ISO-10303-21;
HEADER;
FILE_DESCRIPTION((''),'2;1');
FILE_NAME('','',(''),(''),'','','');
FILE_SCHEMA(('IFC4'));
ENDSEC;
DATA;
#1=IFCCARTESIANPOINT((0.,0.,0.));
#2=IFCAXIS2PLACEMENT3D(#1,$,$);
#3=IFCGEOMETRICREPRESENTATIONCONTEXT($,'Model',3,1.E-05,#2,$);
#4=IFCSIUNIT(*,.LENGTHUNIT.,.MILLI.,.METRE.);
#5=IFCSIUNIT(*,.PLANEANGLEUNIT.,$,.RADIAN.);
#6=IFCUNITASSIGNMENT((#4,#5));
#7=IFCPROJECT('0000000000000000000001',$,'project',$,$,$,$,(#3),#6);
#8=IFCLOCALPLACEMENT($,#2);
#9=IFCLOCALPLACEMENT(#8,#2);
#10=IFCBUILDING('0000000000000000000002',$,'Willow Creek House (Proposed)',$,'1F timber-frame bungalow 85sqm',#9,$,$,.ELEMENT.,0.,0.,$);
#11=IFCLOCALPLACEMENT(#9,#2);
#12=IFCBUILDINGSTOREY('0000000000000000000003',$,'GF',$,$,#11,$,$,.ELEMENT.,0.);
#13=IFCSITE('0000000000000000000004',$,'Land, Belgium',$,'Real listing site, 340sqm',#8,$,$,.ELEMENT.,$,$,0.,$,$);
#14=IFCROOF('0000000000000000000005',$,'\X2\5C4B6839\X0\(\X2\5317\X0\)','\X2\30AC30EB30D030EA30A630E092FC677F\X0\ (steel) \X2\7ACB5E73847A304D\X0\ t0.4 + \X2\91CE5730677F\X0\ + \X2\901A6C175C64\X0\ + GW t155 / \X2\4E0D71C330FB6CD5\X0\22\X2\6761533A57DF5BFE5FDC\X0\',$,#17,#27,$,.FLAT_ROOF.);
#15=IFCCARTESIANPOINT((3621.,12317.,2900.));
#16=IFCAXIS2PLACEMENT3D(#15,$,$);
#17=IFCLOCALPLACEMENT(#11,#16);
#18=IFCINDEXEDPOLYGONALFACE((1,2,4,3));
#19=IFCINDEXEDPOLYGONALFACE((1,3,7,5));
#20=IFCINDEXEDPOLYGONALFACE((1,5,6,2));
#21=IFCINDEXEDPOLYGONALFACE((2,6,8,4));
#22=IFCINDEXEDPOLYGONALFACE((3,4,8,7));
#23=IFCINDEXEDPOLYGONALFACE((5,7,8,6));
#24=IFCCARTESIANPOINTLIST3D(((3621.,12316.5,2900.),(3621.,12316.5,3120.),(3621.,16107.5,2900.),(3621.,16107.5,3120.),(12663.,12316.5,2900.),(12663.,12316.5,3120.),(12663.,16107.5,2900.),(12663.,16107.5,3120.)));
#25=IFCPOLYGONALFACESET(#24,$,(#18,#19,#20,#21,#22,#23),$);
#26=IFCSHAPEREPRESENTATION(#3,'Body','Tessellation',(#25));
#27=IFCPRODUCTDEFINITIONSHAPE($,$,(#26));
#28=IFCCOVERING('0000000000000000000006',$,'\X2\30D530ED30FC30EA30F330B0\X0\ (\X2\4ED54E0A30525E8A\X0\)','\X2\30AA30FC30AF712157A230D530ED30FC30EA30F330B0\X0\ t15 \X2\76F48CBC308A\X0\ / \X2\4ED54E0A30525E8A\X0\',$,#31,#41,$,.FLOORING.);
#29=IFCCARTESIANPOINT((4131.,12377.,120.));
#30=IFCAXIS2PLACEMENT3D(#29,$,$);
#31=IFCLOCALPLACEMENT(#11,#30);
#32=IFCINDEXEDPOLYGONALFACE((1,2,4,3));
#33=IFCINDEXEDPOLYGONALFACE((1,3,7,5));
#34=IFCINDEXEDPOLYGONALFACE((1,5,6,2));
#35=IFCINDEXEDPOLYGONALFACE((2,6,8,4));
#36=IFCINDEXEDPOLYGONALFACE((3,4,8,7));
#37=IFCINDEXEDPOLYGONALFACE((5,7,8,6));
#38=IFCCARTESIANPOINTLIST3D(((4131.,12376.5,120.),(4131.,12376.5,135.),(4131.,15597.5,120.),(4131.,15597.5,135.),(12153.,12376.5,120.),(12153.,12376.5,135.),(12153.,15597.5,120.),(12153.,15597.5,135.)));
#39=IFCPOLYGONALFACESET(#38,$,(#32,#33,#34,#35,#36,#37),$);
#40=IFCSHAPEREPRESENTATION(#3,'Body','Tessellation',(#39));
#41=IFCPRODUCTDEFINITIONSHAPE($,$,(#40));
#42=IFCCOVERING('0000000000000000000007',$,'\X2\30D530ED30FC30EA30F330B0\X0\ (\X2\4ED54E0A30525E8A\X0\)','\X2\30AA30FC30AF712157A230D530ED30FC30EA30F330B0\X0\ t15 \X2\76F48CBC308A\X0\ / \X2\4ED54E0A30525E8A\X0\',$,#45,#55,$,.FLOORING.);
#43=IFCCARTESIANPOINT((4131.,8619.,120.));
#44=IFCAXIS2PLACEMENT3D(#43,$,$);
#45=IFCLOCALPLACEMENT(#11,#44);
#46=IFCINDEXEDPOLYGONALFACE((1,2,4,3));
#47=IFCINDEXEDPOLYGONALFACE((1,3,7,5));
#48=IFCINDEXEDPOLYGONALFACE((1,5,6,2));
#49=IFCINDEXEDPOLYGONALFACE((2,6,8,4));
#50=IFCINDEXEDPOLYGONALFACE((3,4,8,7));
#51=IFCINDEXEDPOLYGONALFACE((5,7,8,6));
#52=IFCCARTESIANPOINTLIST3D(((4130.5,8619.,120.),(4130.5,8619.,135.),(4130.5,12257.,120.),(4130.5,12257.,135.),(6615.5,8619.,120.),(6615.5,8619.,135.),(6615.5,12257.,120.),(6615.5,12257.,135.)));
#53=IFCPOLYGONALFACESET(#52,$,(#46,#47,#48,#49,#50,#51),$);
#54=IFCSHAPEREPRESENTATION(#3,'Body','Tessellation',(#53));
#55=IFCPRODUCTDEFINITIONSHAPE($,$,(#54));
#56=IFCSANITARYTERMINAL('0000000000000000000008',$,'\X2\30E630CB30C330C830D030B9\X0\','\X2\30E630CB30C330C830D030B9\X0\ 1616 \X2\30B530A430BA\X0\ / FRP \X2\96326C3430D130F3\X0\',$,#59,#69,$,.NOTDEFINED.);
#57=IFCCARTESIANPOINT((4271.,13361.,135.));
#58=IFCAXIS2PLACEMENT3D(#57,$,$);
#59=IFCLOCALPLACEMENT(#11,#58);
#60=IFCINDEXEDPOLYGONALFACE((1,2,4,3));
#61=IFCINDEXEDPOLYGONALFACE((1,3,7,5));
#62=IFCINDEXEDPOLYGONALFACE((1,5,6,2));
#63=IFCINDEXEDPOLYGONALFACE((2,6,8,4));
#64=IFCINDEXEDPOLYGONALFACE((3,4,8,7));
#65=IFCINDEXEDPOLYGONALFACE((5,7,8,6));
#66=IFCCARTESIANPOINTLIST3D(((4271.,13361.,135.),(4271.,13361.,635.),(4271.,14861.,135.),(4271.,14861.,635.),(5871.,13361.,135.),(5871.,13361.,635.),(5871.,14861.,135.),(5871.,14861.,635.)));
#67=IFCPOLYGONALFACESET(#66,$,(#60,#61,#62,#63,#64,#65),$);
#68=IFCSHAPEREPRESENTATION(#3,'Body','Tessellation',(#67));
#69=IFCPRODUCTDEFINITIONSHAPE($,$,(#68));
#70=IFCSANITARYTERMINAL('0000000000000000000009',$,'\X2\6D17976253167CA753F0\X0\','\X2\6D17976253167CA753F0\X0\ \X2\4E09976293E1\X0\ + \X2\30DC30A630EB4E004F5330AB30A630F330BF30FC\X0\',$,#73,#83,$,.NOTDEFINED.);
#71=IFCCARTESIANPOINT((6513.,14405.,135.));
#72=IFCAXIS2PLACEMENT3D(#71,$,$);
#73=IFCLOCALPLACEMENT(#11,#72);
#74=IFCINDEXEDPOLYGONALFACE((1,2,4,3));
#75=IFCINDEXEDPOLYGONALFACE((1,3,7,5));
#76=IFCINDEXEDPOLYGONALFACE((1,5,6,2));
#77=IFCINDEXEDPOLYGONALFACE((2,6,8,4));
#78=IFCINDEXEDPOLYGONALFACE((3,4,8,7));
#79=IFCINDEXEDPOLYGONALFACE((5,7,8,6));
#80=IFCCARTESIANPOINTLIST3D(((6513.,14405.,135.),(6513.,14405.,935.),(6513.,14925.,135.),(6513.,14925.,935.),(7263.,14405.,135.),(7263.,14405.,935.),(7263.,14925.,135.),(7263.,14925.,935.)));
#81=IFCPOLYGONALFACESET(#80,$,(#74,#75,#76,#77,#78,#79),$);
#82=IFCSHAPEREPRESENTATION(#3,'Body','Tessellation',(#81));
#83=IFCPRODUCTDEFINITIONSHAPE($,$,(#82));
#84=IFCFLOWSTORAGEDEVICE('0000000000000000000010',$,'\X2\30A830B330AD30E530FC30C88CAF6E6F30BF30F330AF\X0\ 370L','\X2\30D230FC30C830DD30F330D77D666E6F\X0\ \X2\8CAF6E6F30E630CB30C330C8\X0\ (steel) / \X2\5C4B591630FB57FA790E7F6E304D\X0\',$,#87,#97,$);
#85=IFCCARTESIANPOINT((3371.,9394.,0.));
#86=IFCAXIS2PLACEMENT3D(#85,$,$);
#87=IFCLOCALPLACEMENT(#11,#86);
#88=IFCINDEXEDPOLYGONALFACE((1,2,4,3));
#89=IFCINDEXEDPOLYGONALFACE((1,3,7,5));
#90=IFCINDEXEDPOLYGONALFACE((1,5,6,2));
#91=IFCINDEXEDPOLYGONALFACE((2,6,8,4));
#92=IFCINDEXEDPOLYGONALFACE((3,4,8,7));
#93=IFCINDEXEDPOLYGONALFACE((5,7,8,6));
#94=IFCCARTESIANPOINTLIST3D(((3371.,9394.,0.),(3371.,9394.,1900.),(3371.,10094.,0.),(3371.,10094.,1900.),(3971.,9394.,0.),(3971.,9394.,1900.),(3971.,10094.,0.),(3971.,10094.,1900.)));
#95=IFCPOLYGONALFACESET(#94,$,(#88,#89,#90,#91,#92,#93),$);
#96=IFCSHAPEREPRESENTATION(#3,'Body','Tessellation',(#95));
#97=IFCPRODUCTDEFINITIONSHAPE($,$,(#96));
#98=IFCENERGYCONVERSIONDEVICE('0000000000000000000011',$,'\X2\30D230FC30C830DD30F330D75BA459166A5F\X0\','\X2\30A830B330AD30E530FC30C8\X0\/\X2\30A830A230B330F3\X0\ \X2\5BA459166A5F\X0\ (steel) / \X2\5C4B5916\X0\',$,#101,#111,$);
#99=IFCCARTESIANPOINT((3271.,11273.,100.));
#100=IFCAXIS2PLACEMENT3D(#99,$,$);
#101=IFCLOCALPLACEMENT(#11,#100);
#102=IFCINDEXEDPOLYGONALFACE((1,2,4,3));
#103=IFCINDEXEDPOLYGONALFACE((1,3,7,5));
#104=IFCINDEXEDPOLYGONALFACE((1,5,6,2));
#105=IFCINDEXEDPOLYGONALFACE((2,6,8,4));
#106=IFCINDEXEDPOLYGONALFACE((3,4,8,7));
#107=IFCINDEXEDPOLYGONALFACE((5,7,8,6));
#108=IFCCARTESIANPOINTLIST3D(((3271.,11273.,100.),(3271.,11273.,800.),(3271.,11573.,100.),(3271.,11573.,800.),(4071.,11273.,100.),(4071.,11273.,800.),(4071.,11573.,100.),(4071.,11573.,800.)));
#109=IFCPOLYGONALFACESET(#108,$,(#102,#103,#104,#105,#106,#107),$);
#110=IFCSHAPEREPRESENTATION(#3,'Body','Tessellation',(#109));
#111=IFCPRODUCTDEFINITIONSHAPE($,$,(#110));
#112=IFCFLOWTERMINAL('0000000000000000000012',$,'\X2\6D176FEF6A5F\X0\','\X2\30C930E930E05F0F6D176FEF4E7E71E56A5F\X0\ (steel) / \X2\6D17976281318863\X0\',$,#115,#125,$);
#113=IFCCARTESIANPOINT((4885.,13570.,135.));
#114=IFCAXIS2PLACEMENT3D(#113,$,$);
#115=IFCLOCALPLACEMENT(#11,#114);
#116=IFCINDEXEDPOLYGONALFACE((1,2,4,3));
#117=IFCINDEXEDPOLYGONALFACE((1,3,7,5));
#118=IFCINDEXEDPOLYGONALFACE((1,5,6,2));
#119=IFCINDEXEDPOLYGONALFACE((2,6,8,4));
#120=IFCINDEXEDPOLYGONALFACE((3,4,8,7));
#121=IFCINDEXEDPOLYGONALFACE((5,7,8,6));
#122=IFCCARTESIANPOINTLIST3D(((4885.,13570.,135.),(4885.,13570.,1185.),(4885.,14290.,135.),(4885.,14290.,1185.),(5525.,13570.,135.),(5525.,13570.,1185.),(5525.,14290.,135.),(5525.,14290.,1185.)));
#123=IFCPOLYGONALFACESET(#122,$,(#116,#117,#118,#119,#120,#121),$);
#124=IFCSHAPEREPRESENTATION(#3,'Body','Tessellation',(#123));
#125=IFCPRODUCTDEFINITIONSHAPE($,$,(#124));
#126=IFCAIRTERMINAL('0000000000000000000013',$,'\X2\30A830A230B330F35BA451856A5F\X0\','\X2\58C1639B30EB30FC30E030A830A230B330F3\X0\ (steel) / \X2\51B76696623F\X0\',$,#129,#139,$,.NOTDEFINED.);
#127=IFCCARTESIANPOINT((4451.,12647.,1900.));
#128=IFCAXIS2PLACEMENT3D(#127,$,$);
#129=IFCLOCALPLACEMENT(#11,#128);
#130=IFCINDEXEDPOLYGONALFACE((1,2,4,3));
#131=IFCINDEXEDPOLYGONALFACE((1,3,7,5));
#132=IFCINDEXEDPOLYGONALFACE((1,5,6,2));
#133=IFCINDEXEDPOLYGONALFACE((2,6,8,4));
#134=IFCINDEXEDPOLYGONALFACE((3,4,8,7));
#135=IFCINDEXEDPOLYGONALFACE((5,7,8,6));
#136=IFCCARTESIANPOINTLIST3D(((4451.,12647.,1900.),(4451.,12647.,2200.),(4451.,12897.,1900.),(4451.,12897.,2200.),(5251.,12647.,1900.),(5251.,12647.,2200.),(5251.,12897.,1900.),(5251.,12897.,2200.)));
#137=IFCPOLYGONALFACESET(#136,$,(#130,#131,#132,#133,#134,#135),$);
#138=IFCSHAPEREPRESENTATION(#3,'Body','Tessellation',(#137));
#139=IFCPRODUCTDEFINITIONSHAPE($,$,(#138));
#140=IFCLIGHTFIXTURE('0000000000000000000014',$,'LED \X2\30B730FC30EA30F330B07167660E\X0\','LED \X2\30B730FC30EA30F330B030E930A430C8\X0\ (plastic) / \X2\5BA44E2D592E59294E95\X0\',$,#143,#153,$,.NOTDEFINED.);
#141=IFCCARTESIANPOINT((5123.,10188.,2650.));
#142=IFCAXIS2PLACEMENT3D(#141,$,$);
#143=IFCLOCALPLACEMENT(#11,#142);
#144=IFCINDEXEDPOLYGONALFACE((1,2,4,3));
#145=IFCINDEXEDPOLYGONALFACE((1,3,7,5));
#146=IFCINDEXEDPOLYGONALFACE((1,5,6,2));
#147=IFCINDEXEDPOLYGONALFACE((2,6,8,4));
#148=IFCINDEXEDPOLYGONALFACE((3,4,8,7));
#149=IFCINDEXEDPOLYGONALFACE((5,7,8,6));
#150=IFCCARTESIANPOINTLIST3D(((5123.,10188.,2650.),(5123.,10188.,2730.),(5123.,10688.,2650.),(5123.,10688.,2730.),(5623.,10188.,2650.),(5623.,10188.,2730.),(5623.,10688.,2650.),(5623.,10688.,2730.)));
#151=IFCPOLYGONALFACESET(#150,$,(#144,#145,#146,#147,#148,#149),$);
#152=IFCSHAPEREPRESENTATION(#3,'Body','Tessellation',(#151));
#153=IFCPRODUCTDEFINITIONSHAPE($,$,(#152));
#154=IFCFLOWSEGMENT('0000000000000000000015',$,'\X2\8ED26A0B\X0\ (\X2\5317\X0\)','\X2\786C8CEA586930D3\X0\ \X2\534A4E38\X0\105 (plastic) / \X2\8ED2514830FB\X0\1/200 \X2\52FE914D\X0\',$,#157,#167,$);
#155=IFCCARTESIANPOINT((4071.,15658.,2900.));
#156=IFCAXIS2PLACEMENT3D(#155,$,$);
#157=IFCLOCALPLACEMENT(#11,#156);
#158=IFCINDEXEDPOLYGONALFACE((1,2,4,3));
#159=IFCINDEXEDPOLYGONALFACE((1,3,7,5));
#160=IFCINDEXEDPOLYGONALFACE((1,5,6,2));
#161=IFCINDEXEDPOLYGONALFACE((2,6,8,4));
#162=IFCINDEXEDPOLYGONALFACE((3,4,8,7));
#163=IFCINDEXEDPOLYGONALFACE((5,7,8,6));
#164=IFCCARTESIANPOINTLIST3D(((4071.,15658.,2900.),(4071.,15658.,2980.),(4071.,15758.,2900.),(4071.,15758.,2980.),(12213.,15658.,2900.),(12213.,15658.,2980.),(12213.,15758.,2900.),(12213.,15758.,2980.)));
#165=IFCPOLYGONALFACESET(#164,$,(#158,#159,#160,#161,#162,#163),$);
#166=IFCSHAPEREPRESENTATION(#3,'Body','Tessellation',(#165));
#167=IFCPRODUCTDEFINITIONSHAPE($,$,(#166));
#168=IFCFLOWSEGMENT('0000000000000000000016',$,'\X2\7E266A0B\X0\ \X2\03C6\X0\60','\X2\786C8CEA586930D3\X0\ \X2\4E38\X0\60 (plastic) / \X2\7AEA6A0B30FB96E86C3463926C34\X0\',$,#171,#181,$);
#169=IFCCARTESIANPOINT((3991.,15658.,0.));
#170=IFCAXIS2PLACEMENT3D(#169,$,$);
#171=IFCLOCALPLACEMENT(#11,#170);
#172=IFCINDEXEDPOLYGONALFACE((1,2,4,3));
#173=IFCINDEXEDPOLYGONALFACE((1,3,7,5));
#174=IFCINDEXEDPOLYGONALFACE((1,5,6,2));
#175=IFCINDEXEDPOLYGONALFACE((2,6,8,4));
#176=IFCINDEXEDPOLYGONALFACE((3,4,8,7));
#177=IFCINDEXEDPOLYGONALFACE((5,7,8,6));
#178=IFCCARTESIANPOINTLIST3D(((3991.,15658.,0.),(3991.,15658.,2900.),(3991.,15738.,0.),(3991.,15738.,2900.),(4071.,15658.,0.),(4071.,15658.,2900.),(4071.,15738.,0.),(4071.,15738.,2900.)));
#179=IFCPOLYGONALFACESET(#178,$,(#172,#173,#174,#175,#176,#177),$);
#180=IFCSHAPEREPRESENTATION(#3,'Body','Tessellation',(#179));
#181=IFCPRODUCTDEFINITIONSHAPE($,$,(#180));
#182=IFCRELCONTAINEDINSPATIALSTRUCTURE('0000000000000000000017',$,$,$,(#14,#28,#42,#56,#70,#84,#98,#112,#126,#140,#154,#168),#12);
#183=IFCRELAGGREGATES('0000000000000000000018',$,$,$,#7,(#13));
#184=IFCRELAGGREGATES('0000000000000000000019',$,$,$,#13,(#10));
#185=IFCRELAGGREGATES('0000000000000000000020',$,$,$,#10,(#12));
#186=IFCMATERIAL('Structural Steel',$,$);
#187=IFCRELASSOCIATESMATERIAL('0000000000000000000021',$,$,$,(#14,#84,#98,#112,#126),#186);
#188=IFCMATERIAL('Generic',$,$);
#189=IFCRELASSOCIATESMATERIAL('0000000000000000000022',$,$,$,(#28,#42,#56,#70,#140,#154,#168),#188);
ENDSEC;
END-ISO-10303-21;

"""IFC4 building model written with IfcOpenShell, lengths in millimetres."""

from ifc_helpers import new_model, si_unit, frame, frame_2d, origin, place, context, project, spatial, rectangle, extrude, material, element, save


model = new_model("IFC4")

# Units and contexts
model_context = context("Model", 3, precision=1e-05, world=origin())
ifc_project = project(units=[si_unit("LENGTHUNIT", "METRE", prefix="MILLI"), si_unit("PLANEANGLEUNIT", "RADIAN")], contexts=[model_context])

# Site, building, storey
site_placement = place(None, origin())
site = spatial("IfcSite", under=ifc_project, at=site_placement, Name="Land, Belgium", ObjectType="Real listing site, 340sqm", CompositionType="ELEMENT", RefElevation=0.0)
building_placement = place(site_placement, origin())
building = spatial("IfcBuilding", under=site, at=building_placement, Name="Willow Creek House (Proposed)", ObjectType="1F timber-frame bungalow 85sqm", CompositionType="ELEMENT", ElevationOfRefHeight=0.0, ElevationOfTerrain=0.0)
storey_placement = place(building_placement, origin())
storey = spatial("IfcBuildingStorey", under=building, at=storey_placement, Name="GF", CompositionType="ELEMENT", Elevation=0.0)

# Roof
ifc_material_1 = material(Name="Structural Steel")
roof_placement = place(storey_placement, frame((3621.0, 12317.0, 2900.0)))
element("IfcRoof", 1, at=roof_placement, inside=storey, material=ifc_material_1, Name="屋根(北)", Description="ガルバリウム鋼板 (steel) 立平葺き t0.4 + 野地板 + 通気層 + GW t155 / 不燃・法22条区域対応", PredefinedType="FLAT_ROOF", context=model_context, shape_type="SweptSolid", body=[
    extrude(rectangle(XDim=9042.0, YDim=3791.0, at=frame_2d((4521.0, 1895.0))), frame((3621.0, 12317.0, 2900.0)), (0.0, 0.0, 1.0), 220.0),
])

# Coverings
ifc_material_2 = material(Name="Generic")
covering_1_placement = place(storey_placement, frame((4131.0, 12377.0, 120.0)))
element("IfcCovering", 2, at=covering_1_placement, inside=storey, material=ifc_material_2, Name="フローリング (仕上げ床)", Description="オーク無垢フローリング t15 直貼り / 仕上げ床", PredefinedType="FLOORING", context=model_context, shape_type="SweptSolid", body=[
    extrude(rectangle(XDim=8022.0, YDim=3221.0, at=frame_2d((4011.0, 1610.0))), frame((4131.0, 12377.0, 120.0)), (0.0, 0.0, 1.0), 15.0),
])
covering_2_placement = place(storey_placement, frame((4131.0, 8619.0, 120.0)))
element("IfcCovering", 3, at=covering_2_placement, inside=storey, material=ifc_material_2, Name="フローリング (仕上げ床)", Description="オーク無垢フローリング t15 直貼り / 仕上げ床", PredefinedType="FLOORING", context=model_context, shape_type="SweptSolid", body=[
    extrude(rectangle(XDim=2485.0, YDim=3638.0, at=frame_2d((1242.0, 1819.0))), frame((4131.0, 8619.0, 120.0)), (0.0, 0.0, 1.0), 15.0),
])

# Sanitary terminals
sanitary_terminal_1_placement = place(storey_placement, frame((4271.0, 13361.0, 135.0)))
element("IfcSanitaryTerminal", 4, at=sanitary_terminal_1_placement, inside=storey, material=ifc_material_2, Name="ユニットバス", Description="ユニットバス 1616 サイズ / FRP 防水パン", PredefinedType="NOTDEFINED", context=model_context, shape_type="SweptSolid", body=[
    extrude(rectangle(XDim=1600.0, YDim=1500.0, at=frame_2d((800.0, 750.0))), frame((4271.0, 13361.0, 135.0)), (0.0, 0.0, 1.0), 500.0),
])
sanitary_terminal_2_placement = place(storey_placement, frame((6513.0, 14405.0, 135.0)))
element("IfcSanitaryTerminal", 5, at=sanitary_terminal_2_placement, inside=storey, material=ifc_material_2, Name="洗面化粧台", Description="洗面化粧台 三面鏡 + ボウル一体カウンター", PredefinedType="NOTDEFINED", context=model_context, shape_type="SweptSolid", body=[
    extrude(rectangle(XDim=750.0, YDim=520.0, at=frame_2d((375.0, 260.0))), frame((6513.0, 14405.0, 135.0)), (0.0, 0.0, 1.0), 800.0),
])

# Flow storage device
flow_storage_device_placement = place(storey_placement, frame((3371.0, 9394.0, 0.0)))
element("IfcFlowStorageDevice", 6, at=flow_storage_device_placement, inside=storey, material=ifc_material_1, Name="エコキュート貯湯タンク 370L", Description="ヒートポンプ給湯 貯湯ユニット (steel) / 屋外・基礎置き", context=model_context, shape_type="SweptSolid", body=[
    extrude(rectangle(XDim=600.0, YDim=700.0, at=frame_2d((300.0, 350.0))), frame((3371.0, 9394.0, 0.0)), (0.0, 0.0, 1.0), 1900.0),
])

# Energy conversion device
energy_conversion_device_placement = place(storey_placement, frame((3271.0, 11273.0, 100.0)))
element("IfcEnergyConversionDevice", 7, at=energy_conversion_device_placement, inside=storey, material=ifc_material_1, Name="ヒートポンプ室外機", Description="エコキュート/エアコン 室外機 (steel) / 屋外", context=model_context, shape_type="SweptSolid", body=[
    extrude(rectangle(XDim=800.0, YDim=300.0, at=frame_2d((400.0, 150.0))), frame((3271.0, 11273.0, 100.0)), (0.0, 0.0, 1.0), 700.0),
])

# Flow terminal
flow_terminal_placement = place(storey_placement, frame((4885.0, 13570.0, 135.0)))
element("IfcFlowTerminal", 8, at=flow_terminal_placement, inside=storey, material=ifc_material_1, Name="洗濯機", Description="ドラム式洗濯乾燥機 (steel) / 洗面脱衣", context=model_context, shape_type="SweptSolid", body=[
    extrude(rectangle(XDim=640.0, YDim=720.0, at=frame_2d((320.0, 360.0))), frame((4885.0, 13570.0, 135.0)), (0.0, 0.0, 1.0), 1050.0),
])

# Air terminal
air_terminal_placement = place(storey_placement, frame((4451.0, 12647.0, 1900.0)))
element("IfcAirTerminal", 9, at=air_terminal_placement, inside=storey, material=ifc_material_1, Name="エアコン室内機", Description="壁掛ルームエアコン (steel) / 冷暖房", PredefinedType="NOTDEFINED", context=model_context, shape_type="SweptSolid", body=[
    extrude(rectangle(XDim=800.0, YDim=250.0, at=frame_2d((400.0, 125.0))), frame((4451.0, 12647.0, 1900.0)), (0.0, 0.0, 1.0), 300.0),
])

# Light fixture
light_fixture_placement = place(storey_placement, frame((5123.0, 10188.0, 2650.0)))
element("IfcLightFixture", 10, at=light_fixture_placement, inside=storey, material=ifc_material_2, Name="LED シーリング照明", Description="LED シーリングライト (plastic) / 室中央天井", PredefinedType="NOTDEFINED", context=model_context, shape_type="SweptSolid", body=[
    extrude(rectangle(XDim=500.0, YDim=500.0, at=frame_2d((250.0, 250.0))), frame((5123.0, 10188.0, 2650.0)), (0.0, 0.0, 1.0), 80.0),
])

# Flow segments
flow_segment_1_placement = place(storey_placement, frame((4071.0, 15658.0, 2900.0)))
element("IfcFlowSegment", 11, at=flow_segment_1_placement, inside=storey, material=ifc_material_2, Name="軒樋 (北)", Description="硬質塩ビ 半丸105 (plastic) / 軒先・1/200 勾配", context=model_context, shape_type="SweptSolid", body=[
    extrude(rectangle(XDim=8142.0, YDim=100.0, at=frame_2d((4071.0, 50.0))), frame((4071.0, 15658.0, 2900.0)), (0.0, 0.0, 1.0), 80.0),
])
flow_segment_2_placement = place(storey_placement, frame((3991.0, 15658.0, 0.0)))
element("IfcFlowSegment", 12, at=flow_segment_2_placement, inside=storey, material=ifc_material_2, Name="縦樋 φ60", Description="硬質塩ビ 丸60 (plastic) / 竪樋・雨水排水", context=model_context, shape_type="SweptSolid", body=[
    extrude(rectangle(XDim=80.0, YDim=80.0, at=frame_2d((40.0, 40.0))), frame((3991.0, 15658.0, 0.0)), (0.0, 0.0, 1.0), 2900.0),
])

save(model, "model.ifc")
